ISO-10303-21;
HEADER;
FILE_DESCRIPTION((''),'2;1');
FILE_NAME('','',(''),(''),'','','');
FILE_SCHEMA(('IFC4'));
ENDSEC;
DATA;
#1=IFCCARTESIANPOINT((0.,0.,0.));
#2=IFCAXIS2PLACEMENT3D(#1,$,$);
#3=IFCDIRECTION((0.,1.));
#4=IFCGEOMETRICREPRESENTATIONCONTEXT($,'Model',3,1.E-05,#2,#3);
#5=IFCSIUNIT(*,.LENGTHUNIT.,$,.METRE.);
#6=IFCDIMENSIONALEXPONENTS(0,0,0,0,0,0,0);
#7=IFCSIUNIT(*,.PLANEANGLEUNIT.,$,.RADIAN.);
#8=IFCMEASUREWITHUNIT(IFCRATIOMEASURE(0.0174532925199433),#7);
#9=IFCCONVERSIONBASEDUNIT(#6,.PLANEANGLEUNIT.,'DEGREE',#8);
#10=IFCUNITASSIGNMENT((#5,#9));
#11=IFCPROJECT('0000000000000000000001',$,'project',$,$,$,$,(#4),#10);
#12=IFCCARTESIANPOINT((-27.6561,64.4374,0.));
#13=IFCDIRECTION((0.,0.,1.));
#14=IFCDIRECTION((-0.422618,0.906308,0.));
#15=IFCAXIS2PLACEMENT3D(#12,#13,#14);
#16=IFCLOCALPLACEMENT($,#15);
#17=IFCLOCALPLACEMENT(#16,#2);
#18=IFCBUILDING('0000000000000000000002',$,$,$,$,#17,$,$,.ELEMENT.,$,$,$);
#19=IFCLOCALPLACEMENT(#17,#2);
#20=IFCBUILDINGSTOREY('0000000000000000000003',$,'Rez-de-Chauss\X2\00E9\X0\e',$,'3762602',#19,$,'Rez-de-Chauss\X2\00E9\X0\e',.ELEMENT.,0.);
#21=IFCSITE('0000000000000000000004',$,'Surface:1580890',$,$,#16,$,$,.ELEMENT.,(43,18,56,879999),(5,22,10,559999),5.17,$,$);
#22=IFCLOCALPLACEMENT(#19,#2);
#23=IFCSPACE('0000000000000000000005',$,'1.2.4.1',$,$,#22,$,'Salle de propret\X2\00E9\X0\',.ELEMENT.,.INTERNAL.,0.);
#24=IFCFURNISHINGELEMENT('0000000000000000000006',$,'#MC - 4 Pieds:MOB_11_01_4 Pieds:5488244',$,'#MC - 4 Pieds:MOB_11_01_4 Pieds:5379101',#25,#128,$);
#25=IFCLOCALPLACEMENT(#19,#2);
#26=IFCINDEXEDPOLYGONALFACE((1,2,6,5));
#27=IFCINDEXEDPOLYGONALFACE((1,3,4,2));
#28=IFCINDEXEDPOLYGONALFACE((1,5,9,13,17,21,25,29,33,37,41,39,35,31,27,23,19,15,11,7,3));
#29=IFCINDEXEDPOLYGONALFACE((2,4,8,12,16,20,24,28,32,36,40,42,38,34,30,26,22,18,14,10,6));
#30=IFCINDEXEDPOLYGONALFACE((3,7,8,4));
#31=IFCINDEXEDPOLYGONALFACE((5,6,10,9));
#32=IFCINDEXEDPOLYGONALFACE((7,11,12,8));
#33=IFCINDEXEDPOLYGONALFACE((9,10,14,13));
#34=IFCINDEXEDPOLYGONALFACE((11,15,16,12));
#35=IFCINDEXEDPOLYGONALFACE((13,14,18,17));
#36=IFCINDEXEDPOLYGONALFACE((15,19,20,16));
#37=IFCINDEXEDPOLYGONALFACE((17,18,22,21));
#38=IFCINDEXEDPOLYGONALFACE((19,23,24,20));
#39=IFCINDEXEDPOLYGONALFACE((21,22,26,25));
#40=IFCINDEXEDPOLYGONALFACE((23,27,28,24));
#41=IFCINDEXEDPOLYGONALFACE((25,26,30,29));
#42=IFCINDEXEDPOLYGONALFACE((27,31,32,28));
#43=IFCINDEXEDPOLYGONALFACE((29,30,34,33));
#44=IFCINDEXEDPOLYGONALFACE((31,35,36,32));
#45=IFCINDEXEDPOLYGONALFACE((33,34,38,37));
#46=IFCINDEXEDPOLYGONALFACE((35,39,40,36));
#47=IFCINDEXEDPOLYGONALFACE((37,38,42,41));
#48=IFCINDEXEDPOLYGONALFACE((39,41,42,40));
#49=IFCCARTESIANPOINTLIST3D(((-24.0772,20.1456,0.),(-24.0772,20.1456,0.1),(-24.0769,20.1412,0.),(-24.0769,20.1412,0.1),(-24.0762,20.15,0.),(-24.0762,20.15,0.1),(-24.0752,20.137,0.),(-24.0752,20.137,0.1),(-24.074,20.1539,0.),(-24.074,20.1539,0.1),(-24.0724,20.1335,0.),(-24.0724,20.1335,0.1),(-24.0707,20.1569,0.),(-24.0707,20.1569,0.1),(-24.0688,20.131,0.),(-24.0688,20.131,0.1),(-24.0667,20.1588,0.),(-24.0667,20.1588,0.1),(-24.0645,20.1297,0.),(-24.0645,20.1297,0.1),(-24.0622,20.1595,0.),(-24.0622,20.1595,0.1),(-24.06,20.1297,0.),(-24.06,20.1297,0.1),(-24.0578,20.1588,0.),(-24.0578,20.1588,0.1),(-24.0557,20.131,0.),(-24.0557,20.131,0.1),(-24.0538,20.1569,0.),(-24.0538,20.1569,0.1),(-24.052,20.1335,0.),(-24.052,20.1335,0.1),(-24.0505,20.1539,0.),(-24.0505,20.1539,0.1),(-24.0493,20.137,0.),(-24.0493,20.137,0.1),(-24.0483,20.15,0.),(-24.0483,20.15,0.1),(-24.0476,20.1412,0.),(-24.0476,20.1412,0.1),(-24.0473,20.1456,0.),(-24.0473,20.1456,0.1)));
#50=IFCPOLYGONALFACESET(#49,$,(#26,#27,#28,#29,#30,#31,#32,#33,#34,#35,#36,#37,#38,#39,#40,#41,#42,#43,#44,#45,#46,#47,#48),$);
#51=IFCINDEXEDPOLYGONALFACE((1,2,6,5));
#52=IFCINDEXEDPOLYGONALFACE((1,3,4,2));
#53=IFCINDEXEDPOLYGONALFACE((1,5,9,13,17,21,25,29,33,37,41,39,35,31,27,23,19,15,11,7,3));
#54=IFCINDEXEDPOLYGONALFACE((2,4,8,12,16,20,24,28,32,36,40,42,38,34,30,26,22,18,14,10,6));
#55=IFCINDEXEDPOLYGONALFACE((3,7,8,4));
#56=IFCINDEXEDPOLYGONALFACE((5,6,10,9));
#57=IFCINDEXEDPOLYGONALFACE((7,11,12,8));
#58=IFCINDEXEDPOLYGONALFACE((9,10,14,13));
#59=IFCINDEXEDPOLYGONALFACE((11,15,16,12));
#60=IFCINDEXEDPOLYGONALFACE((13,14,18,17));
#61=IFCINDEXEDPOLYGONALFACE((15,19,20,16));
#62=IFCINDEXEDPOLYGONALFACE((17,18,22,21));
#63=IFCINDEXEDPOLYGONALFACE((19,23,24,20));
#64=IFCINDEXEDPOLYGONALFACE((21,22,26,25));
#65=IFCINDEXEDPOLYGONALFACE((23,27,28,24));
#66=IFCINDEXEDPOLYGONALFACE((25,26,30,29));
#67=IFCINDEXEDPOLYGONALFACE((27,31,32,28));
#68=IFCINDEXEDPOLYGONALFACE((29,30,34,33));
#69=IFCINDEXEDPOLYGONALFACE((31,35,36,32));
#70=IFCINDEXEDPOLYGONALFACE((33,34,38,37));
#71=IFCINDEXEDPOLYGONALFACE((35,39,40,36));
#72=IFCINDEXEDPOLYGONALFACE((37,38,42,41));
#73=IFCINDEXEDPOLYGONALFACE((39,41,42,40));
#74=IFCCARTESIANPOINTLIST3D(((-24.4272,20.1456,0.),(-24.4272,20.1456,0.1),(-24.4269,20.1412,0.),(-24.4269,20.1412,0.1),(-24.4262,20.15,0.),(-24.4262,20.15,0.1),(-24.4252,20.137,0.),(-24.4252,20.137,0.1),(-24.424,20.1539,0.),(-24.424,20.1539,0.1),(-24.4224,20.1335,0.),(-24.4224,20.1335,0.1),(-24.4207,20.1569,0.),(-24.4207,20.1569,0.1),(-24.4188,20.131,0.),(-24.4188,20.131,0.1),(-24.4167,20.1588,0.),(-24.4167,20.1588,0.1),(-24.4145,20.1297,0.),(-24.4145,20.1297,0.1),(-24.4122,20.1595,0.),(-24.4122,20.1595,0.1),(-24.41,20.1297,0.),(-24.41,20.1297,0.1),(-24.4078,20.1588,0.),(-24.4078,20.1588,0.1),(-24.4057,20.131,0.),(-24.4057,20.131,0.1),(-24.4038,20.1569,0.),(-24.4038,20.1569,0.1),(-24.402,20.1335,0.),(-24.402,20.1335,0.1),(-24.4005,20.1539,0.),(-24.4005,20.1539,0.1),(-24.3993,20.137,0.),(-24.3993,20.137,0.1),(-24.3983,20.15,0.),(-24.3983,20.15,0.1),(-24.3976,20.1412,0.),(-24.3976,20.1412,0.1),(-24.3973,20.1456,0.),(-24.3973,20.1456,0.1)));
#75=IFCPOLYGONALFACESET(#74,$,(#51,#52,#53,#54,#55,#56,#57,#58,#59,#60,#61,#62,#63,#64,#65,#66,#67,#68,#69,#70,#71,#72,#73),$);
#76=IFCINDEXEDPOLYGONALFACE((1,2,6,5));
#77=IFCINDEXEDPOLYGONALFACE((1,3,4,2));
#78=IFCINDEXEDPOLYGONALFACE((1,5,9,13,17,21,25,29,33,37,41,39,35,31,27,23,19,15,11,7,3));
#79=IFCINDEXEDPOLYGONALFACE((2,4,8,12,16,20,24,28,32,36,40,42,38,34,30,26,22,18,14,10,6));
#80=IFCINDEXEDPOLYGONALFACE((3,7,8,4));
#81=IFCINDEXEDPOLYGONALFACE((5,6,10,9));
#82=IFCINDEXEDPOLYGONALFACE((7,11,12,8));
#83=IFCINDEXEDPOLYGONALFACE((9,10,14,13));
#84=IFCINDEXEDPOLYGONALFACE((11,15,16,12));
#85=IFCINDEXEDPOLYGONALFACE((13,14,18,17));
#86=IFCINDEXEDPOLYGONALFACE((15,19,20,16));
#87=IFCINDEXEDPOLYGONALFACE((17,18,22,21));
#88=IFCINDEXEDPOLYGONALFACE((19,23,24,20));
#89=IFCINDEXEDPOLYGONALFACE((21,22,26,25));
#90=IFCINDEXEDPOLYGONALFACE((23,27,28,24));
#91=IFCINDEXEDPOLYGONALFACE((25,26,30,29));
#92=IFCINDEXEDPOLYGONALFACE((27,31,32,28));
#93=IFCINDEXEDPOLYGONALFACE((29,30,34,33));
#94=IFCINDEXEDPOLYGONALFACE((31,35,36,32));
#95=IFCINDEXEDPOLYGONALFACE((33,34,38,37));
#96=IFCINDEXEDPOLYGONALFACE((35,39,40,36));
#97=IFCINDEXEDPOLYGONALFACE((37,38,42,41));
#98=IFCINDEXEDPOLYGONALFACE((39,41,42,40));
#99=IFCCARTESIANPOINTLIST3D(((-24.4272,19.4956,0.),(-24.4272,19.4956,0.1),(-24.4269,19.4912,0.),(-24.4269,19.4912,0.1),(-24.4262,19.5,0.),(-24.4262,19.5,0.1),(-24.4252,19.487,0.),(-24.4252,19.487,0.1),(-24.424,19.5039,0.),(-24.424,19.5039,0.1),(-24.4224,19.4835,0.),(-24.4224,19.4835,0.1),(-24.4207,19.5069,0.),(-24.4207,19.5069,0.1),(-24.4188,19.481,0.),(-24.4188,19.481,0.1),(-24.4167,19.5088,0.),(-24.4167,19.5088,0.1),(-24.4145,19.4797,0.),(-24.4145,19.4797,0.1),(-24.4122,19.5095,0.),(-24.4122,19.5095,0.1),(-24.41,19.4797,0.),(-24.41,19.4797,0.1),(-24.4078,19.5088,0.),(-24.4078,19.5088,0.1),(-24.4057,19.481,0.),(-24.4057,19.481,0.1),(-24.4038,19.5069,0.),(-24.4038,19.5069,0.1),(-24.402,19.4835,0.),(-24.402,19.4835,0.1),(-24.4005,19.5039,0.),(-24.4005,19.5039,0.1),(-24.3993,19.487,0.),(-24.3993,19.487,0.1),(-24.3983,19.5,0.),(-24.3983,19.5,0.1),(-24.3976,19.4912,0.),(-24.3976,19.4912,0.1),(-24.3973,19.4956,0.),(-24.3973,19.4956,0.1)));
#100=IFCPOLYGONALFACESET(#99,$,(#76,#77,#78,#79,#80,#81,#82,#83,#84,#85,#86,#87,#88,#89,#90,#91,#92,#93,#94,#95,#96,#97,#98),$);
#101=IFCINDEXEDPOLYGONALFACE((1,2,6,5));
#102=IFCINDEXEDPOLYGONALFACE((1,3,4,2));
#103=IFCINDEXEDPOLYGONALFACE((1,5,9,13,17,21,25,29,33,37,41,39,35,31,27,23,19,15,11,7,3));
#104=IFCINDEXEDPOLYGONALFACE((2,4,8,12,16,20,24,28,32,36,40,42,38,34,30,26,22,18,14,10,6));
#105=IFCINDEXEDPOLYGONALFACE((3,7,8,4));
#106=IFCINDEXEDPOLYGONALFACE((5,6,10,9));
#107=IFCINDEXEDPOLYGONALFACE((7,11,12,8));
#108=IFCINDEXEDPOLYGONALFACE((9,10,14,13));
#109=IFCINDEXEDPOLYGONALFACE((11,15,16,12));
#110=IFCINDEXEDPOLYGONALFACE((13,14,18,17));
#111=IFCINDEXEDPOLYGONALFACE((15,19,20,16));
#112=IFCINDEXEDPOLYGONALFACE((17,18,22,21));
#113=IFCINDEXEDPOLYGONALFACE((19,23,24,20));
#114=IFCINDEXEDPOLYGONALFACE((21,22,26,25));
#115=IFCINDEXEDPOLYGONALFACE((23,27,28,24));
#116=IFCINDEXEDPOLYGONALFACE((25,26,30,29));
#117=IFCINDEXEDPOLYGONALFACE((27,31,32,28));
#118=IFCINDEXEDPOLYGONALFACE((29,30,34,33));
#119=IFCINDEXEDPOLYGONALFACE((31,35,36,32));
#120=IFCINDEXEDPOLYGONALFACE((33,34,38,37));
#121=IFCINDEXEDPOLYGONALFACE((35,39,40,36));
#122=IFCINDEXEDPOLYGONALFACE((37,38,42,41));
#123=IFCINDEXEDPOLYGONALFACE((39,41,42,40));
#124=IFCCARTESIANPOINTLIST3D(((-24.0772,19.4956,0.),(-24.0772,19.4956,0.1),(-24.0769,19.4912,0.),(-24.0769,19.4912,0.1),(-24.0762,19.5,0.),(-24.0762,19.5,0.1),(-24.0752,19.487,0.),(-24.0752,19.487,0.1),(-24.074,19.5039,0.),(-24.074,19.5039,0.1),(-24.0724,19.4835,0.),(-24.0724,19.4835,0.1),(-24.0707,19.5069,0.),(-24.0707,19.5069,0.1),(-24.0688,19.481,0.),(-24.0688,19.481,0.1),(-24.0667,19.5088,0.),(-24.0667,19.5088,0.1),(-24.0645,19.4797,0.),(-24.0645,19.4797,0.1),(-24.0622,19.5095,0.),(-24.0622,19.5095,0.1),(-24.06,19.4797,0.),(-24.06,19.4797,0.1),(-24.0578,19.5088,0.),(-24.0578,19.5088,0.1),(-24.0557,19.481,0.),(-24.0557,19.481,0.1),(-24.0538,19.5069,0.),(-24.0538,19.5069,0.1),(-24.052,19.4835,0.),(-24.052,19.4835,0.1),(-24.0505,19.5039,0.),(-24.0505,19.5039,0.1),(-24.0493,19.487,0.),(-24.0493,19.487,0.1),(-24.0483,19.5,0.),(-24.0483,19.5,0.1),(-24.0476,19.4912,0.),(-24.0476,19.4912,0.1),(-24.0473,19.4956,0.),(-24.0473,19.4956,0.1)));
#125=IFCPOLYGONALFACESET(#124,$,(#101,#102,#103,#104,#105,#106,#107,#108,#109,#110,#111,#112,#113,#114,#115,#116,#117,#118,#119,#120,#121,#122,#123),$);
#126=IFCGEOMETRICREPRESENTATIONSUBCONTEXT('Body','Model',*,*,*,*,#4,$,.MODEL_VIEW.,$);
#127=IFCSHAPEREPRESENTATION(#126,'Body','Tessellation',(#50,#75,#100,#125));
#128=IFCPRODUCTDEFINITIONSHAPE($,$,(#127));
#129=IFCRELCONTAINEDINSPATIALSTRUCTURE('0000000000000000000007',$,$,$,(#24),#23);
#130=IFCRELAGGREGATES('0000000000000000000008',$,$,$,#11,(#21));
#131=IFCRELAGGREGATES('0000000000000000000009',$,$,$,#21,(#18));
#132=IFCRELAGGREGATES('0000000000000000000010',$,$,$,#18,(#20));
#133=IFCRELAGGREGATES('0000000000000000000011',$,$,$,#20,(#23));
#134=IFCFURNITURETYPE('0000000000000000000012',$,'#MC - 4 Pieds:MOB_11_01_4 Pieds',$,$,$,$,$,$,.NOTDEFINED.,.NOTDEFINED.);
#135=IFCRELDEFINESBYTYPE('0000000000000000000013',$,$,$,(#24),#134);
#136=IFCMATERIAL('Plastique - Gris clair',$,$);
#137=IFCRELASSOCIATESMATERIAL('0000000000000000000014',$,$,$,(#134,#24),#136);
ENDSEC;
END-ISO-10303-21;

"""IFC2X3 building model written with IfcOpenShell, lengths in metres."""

from ifc_helpers import new_model, entity, si_unit, converted_unit, direction, frame, frame_2d, origin, origin_2d_with_axis, place, context, subcontext, project, spatial, circle, extrude, source, transform, mapped, material, type_object, type_shapes, element, save


model = new_model("IFC2X3")

# Units and contexts
model_context = context("Model", 3, precision=1e-05, world=origin(), true_north=direction((0.0, 1.0)))
body_context = subcontext(model_context, "Body", "Model", "MODEL_VIEW")
ifc_project = project(units=[si_unit("LENGTHUNIT", "METRE"), converted_unit("PLANEANGLEUNIT", "DEGREE", entity("IfcRatioMeasure", 0.0174532925199433), si_unit("PLANEANGLEUNIT", "RADIAN"), dimensions=[0, 0, 0, 0, 0, 0, 0])], contexts=[model_context])

# Site, building, storey
site_placement = place(None, frame((-27.6561, 64.4374, 0.0), z_axis=(0.0, 0.0, 1.0), x_axis=(-0.422618, 0.906308, 0.0)))
site = spatial("IfcSite", under=ifc_project, at=site_placement, Name="Surface:1580890", CompositionType="ELEMENT", RefLatitude=(43, 18, 56, 879999), RefLongitude=(5, 22, 10, 559999), RefElevation=5.17)
building_placement = place(site_placement, origin())
building = spatial("IfcBuilding", under=site, at=building_placement, CompositionType="ELEMENT")
storey_placement = place(building_placement, origin())
storey = spatial("IfcBuildingStorey", under=building, at=storey_placement, Name="Rez-de-Chaussée", ObjectType="3762602", LongName="Rez-de-Chaussée", CompositionType="ELEMENT", Elevation=0.0)

# Shared definitions
space_placement = place(storey_placement, origin())
space = spatial("IfcSpace", under=storey, at=space_placement, Name="1.2.4.1", LongName="Salle de propreté", CompositionType="ELEMENT", InteriorOrExteriorSpace="INTERNAL", ElevationWithFlooring=0.0)

# Furnishing element
ifc_material_1 = material(Name="Plastique - Gris clair")
furniture_type_1 = type_object("IfcFurnitureType", Name="#MC - 4 Pieds:MOB_11_01_4 Pieds", material=ifc_material_1)
shared_shape_1 = source(origin(), body_context, "Body", "SweptSolid", [
    extrude(circle(Radius=0.015, at=frame_2d((0.0, 0.0), x_axis=(1.0, 0.0))), frame((0.3303, 0.15, 0.0)), (0.0, 0.0, 1.0), 0.1),
    extrude(circle(Radius=0.015, at=origin_2d_with_axis()), frame((0.3303, 0.5, 0.0)), (0.0, 0.0, 1.0), 0.1),
    extrude(circle(Radius=0.015, at=frame_2d((0.0, 0.0), x_axis=(1.0, 0.0))), frame((-0.3197, 0.5, 0.0)), (0.0, 0.0, 1.0), 0.1),
    extrude(circle(Radius=0.015, at=frame_2d((0.0, 0.0), x_axis=(1.0, 0.0))), frame((-0.3197, 0.15, 0.0)), (0.0, 0.0, 1.0), 0.1),
])
type_shapes(furniture_type_1, [shared_shape_1])
for number, where, z_axis, x_axis, name in (
    (1, (-23.9122, 19.8142, 0.0), (0.0, 0.0, 1.0), (0.0, 1.0, 0.0), "#MC - 4 Pieds:MOB_11_01_4 Pieds:5488244"),
):
    element("IfcFurnishingElement", number, at=place(space_placement, frame(where, z_axis=z_axis, x_axis=x_axis)), inside=space, type_object=furniture_type_1, material=ifc_material_1, Name=name, ObjectType="#MC - 4 Pieds:MOB_11_01_4 Pieds:5379101", context=body_context, shape_type="MappedRepresentation", body=[
        mapped(shared_shape_1, transform((0.0, 0.0, 0.0), scale=1.0)),
    ])

save(model, "model.ifc")
